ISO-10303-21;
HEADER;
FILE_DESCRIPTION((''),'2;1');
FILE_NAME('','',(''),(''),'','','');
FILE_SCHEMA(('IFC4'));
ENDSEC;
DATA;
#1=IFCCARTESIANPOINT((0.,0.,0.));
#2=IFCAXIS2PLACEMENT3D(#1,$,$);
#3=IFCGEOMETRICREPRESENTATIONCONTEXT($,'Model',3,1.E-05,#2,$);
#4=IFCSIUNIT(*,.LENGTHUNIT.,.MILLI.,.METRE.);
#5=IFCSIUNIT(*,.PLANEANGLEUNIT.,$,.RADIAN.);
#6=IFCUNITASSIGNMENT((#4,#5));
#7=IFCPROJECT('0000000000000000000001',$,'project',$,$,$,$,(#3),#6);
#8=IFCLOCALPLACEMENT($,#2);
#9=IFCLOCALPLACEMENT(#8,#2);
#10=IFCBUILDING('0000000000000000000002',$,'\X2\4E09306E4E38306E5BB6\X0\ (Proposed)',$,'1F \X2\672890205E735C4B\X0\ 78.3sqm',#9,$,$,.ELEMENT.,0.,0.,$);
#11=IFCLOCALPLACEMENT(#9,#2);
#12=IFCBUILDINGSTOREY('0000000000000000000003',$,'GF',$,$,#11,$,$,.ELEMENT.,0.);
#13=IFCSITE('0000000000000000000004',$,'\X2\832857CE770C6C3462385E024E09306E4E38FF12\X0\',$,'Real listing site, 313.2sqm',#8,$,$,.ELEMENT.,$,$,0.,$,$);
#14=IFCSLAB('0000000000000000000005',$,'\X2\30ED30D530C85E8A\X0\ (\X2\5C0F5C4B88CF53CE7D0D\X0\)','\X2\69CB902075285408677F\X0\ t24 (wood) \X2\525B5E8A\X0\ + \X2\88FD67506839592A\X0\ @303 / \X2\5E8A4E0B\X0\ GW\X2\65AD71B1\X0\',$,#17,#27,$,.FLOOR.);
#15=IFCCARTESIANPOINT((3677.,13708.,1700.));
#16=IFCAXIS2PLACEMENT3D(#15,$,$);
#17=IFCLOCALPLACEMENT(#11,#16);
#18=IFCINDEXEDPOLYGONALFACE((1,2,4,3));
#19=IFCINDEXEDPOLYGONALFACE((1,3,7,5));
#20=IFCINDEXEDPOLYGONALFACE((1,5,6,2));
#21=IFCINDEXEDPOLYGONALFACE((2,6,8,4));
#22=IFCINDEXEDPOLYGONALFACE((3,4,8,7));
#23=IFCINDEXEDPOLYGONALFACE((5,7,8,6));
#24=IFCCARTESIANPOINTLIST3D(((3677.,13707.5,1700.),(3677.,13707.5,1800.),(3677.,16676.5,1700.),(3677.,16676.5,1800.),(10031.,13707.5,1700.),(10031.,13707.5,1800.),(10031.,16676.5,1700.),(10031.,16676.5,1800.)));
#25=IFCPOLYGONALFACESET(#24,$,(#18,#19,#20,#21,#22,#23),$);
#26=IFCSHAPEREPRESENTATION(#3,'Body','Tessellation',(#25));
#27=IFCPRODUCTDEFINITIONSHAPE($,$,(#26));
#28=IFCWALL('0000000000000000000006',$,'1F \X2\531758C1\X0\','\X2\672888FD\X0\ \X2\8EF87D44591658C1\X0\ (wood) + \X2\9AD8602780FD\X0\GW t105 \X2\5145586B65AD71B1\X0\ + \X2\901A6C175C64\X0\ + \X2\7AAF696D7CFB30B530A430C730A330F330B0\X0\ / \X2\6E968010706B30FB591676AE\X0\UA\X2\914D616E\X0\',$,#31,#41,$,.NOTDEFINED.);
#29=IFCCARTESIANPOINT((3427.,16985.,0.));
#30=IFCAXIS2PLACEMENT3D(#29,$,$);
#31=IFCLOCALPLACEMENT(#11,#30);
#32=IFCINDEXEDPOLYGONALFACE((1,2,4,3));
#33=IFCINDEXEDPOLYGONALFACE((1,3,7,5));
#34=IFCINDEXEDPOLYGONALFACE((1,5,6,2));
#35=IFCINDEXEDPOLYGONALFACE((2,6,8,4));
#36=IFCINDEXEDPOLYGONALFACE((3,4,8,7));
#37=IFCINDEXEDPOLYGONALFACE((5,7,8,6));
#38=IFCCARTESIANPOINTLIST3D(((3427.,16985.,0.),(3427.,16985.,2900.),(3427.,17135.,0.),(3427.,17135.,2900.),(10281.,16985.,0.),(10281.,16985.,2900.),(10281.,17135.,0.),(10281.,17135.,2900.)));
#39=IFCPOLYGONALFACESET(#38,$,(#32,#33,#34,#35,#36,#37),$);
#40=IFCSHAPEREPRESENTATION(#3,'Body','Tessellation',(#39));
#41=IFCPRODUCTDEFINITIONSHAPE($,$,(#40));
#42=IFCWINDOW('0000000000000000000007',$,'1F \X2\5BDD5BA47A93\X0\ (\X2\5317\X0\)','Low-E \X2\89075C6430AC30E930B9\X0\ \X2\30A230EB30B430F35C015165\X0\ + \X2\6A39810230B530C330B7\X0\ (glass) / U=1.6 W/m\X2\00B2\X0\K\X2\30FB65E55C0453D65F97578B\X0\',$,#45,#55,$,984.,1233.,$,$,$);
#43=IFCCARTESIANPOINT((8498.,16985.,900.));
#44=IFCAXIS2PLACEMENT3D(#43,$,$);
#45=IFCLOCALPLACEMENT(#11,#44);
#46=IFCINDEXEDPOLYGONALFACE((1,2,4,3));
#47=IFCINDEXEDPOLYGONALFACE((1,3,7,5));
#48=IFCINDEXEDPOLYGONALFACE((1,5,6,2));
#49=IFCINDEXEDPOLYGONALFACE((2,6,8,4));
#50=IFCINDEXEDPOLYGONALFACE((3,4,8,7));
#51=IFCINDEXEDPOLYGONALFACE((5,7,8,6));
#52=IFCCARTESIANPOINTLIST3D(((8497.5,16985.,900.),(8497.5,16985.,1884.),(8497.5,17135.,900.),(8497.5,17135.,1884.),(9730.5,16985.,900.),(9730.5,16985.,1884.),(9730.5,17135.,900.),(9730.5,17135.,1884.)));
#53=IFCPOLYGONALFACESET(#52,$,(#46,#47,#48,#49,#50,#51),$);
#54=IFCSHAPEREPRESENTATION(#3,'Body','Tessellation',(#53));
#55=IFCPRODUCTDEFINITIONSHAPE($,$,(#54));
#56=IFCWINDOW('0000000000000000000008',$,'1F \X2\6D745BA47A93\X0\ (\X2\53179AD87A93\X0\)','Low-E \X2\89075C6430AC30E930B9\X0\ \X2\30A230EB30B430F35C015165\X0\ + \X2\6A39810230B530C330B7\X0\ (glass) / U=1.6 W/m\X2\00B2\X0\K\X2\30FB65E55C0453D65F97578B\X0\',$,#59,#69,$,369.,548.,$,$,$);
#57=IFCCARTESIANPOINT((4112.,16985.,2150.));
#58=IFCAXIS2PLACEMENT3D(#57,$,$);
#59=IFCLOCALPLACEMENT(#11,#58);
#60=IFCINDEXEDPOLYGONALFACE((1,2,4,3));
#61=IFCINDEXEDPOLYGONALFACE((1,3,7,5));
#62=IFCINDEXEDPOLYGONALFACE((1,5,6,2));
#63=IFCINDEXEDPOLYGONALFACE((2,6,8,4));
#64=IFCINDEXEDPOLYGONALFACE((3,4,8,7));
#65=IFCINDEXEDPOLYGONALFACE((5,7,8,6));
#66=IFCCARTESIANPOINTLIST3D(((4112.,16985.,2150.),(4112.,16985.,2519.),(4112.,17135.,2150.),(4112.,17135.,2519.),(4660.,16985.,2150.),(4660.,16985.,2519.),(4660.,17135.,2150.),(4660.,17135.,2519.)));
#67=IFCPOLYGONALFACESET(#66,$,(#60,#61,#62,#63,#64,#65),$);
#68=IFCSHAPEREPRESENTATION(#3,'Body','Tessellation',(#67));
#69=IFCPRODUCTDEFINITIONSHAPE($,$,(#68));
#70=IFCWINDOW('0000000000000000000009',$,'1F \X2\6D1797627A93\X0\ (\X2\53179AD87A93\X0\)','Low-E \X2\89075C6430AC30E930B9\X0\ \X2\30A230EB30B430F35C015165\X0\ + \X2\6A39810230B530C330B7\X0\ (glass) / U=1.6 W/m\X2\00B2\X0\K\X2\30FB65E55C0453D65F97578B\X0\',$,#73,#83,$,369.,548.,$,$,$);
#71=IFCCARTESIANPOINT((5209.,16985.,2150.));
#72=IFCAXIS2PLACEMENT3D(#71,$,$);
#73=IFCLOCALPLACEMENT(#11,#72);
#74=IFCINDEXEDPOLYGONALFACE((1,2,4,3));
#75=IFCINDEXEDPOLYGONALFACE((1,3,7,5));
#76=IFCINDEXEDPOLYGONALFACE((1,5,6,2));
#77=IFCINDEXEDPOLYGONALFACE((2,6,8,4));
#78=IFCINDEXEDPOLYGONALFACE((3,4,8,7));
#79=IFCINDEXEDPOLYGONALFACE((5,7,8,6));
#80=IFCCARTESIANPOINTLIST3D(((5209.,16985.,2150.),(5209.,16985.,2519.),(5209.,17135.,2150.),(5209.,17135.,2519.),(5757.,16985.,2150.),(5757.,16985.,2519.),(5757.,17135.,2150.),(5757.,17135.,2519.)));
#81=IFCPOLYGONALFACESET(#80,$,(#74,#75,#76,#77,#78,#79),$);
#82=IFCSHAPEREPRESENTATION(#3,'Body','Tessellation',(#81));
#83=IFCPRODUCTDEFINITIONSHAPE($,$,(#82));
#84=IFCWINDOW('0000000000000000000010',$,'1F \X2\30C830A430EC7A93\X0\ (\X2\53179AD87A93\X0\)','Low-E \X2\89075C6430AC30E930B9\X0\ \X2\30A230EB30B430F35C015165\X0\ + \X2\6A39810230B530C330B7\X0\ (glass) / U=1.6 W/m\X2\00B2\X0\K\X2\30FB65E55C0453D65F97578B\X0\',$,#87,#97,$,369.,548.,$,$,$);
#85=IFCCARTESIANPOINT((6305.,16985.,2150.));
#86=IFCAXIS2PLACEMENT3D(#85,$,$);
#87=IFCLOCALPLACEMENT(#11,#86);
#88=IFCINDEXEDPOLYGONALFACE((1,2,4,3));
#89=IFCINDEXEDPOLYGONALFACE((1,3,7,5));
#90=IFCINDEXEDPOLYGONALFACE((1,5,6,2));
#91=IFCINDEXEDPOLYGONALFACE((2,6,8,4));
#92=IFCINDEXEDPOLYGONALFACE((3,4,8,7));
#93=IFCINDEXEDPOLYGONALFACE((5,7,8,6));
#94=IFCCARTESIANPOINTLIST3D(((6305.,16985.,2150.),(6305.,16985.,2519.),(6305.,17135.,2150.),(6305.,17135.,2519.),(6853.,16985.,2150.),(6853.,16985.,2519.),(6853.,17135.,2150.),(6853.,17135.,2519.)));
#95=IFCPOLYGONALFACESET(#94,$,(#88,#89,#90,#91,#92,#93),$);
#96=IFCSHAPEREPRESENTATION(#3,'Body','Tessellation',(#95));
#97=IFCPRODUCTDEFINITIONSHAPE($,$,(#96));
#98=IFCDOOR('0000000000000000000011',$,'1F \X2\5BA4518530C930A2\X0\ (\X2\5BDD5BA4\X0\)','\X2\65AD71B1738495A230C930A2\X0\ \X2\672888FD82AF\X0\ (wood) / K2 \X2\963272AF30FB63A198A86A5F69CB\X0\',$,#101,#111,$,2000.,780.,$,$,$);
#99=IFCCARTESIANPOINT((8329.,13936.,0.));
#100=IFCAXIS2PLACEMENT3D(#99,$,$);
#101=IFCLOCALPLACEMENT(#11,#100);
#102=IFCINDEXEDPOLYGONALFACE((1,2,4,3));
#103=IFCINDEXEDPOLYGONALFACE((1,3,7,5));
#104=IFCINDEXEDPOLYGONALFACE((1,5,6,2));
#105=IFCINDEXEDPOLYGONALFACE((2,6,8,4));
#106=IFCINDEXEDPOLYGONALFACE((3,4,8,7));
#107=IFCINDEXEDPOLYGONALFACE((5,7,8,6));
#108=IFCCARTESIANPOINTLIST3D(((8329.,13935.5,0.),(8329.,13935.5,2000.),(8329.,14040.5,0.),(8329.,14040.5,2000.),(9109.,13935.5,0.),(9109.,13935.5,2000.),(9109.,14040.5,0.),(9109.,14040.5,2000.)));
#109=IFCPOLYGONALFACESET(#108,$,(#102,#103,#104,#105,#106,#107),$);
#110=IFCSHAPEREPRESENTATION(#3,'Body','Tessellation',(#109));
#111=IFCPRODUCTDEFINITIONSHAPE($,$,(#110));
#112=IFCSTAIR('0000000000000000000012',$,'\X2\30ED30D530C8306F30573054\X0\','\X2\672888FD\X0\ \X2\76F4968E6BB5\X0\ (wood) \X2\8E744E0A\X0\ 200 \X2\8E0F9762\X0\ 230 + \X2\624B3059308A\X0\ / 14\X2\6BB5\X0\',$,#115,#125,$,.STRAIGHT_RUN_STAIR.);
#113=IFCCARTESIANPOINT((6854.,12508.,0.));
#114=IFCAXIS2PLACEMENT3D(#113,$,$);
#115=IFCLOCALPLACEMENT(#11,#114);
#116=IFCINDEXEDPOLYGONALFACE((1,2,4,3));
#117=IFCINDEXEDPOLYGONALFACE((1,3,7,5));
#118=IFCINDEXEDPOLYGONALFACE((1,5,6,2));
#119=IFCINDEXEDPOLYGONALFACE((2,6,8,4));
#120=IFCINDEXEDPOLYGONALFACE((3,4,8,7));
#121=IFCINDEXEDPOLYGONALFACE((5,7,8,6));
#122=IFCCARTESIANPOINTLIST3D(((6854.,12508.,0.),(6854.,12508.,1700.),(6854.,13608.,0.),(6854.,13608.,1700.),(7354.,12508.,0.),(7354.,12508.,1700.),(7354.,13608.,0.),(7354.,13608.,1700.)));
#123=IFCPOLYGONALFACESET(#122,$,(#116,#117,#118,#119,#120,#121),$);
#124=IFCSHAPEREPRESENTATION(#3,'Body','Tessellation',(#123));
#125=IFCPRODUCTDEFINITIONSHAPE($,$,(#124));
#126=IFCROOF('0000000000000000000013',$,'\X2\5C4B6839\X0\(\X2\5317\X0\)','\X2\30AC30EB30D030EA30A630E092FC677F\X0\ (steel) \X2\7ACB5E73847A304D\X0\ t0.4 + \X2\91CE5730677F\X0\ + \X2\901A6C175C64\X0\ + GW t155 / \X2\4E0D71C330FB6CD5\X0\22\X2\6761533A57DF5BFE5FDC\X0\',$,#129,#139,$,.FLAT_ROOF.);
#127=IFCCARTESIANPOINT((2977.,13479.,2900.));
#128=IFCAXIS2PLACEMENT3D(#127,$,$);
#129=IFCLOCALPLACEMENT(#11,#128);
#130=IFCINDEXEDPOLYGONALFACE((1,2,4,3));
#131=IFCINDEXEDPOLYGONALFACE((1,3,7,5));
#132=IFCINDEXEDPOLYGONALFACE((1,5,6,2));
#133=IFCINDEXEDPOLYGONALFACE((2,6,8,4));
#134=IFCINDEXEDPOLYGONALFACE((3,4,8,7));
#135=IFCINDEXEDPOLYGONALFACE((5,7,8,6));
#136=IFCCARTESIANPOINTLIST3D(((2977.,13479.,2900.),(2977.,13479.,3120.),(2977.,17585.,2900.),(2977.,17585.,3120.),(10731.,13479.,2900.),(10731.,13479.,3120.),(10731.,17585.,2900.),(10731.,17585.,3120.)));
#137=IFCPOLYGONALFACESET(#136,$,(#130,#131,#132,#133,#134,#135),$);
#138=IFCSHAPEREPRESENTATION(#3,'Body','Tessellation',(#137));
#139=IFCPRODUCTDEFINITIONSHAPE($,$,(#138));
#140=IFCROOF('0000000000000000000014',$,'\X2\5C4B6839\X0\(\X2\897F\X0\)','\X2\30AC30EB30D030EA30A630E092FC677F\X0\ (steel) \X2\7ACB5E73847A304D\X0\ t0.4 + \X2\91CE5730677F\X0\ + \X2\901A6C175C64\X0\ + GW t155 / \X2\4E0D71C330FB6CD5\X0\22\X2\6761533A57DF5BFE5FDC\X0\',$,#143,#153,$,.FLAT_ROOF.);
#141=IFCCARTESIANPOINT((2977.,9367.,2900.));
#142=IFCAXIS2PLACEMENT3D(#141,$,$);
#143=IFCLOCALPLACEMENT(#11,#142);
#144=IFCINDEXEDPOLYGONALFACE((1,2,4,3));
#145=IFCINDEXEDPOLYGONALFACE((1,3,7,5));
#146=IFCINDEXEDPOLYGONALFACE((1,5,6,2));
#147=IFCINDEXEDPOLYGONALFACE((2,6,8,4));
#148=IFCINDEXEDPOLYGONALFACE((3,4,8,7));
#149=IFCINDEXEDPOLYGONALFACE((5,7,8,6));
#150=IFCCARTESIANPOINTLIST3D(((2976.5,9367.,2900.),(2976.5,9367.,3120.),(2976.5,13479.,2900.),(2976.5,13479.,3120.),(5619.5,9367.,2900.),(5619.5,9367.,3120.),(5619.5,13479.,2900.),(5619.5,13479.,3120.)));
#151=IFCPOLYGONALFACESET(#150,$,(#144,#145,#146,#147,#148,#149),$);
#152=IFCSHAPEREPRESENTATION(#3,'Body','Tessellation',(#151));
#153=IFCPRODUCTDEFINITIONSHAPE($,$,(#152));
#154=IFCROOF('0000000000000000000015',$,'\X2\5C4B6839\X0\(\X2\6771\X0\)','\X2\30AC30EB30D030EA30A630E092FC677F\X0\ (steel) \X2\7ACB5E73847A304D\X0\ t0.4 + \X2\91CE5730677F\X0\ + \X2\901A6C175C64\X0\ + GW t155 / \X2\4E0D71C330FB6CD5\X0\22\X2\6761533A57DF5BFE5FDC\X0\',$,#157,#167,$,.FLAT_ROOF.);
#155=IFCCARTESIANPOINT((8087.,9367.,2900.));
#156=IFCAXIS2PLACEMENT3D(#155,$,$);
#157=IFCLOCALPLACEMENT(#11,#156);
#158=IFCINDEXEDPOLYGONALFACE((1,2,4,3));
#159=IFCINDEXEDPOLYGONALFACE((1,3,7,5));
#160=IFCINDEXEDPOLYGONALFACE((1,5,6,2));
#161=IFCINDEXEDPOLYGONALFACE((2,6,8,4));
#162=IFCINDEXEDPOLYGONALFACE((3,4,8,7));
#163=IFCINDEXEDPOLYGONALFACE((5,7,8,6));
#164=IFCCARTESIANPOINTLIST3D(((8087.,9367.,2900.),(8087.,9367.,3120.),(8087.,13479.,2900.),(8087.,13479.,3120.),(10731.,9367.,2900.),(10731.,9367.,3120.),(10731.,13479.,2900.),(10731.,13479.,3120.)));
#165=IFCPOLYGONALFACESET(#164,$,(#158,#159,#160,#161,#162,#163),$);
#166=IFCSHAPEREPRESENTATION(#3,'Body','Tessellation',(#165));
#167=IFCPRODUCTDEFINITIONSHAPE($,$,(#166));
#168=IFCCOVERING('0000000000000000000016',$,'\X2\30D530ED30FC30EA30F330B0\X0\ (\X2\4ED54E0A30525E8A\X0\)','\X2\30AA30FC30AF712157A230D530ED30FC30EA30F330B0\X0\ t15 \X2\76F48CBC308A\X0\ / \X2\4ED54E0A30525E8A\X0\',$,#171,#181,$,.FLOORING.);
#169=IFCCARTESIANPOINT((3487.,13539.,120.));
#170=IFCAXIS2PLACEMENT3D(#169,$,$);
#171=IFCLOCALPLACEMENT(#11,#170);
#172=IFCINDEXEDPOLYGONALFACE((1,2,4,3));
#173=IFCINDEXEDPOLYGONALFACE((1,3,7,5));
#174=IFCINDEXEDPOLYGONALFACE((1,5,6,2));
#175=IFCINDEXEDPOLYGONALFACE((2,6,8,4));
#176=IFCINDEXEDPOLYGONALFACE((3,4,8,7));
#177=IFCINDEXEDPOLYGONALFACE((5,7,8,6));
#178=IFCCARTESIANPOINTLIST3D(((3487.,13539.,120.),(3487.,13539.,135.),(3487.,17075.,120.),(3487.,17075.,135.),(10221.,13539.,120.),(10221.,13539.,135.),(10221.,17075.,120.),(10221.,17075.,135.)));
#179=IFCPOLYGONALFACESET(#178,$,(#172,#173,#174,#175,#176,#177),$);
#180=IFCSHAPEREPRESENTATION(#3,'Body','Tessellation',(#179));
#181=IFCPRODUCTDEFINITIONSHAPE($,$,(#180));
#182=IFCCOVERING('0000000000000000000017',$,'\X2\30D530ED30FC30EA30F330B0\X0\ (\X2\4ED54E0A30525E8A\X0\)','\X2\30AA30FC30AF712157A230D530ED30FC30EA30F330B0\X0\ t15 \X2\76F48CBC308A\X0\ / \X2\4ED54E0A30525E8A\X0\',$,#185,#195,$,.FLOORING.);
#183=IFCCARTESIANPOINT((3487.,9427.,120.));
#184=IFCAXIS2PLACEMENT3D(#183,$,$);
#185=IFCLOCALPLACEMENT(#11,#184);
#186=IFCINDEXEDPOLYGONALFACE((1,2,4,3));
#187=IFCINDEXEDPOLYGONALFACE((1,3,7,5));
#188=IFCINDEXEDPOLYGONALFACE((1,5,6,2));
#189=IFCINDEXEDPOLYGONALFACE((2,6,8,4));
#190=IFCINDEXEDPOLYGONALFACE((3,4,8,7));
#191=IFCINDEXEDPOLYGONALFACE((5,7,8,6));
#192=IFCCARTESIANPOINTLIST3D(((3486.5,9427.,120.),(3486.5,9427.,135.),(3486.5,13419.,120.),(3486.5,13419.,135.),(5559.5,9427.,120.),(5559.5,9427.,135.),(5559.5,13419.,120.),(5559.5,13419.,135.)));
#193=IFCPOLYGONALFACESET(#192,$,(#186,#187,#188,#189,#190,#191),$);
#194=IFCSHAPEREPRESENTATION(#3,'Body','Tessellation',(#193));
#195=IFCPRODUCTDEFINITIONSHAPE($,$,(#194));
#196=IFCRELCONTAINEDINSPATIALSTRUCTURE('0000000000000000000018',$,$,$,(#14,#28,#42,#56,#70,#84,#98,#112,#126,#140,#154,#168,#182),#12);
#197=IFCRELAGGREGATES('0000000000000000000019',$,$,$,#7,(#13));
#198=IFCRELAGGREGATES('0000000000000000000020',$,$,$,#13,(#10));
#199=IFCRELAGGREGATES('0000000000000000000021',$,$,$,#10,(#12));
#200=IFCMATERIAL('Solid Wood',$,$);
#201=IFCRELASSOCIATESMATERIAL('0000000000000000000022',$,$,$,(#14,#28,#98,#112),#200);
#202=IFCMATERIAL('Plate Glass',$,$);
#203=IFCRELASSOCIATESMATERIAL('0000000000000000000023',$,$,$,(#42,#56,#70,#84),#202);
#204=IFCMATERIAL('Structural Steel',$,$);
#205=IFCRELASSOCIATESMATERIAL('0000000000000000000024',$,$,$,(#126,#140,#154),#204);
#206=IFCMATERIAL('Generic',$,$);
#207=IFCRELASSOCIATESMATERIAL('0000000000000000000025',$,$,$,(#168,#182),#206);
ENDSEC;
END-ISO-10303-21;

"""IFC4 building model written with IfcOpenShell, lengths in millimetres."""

from ifc_helpers import new_model, si_unit, frame, frame_2d, origin, place, context, project, spatial, rectangle, extrude, material, element, fill, save


model = new_model("IFC4")

# Units and contexts
model_context = context("Model", 3, precision=1e-05, world=origin())
ifc_project = project(units=[si_unit("LENGTHUNIT", "METRE", prefix="MILLI"), si_unit("PLANEANGLEUNIT", "RADIAN")], contexts=[model_context])

# Site, building, storey
site_placement = place(None, origin())
site = spatial("IfcSite", under=ifc_project, at=site_placement, Name="茨城県水戸市三の丸２", ObjectType="Real listing site, 313.2sqm", CompositionType="ELEMENT", RefElevation=0.0)
building_placement = place(site_placement, origin())
building = spatial("IfcBuilding", under=site, at=building_placement, Name="三の丸の家 (Proposed)", ObjectType="1F 木造平屋 78.3sqm", CompositionType="ELEMENT", ElevationOfRefHeight=0.0, ElevationOfTerrain=0.0)
storey_placement = place(building_placement, origin())
storey = spatial("IfcBuildingStorey", under=building, at=storey_placement, Name="GF", CompositionType="ELEMENT", Elevation=0.0)

# Slab
ifc_material_1 = material(Name="Solid Wood")
slab_1_placement = place(storey_placement, frame((3677.0, 13708.0, 1700.0)))
element("IfcSlab", 1, at=slab_1_placement, inside=storey, material=ifc_material_1, Name="ロフト床 (小屋裏収納)", Description="構造用合板 t24 (wood) 剛床 + 製材根太 @303 / 床下 GW断熱", PredefinedType="FLOOR", context=model_context, shape_type="SweptSolid", body=[
    extrude(rectangle(XDim=6354.0, YDim=2969.0, at=frame_2d((3177.0, 1484.0))), frame((3677.0, 13708.0, 1700.0)), (0.0, 0.0, 1.0), 100.0),
])

# Wall, openings, windows
wall_1_placement = place(storey_placement, frame((3427.0, 16985.0, 0.0)))
wall_1 = element("IfcWall", 2, at=wall_1_placement, inside=storey, material=ifc_material_1, Name="1F 北壁", Description="木製 軸組外壁 (wood) + 高性能GW t105 充填断熱 + 通気層 + 窯業系サイディング / 準耐火・外皮UA配慮", PredefinedType="NOTDEFINED", context=model_context, shape_type="SweptSolid", body=[
    extrude(rectangle(XDim=6854.0, YDim=150.0, at=frame_2d((3427.0, 75.0))), frame((3427.0, 16985.0, 0.0)), (0.0, 0.0, 1.0), 2900.0),
])
opening_1_placement = place(storey_placement, frame((8498.0, 16985.0, 900.0)))
opening_1 = element("IfcOpeningElement", 3, at=opening_1_placement, cuts=wall_1, PredefinedType="NOTDEFINED", context=model_context, shape_type="SweptSolid", body=[
    extrude(rectangle(XDim=1233.0, YDim=150.0, at=frame_2d((616.0, 75.0))), frame((8498.0, 16985.0, 900.0)), (0.0, 0.0, 1.0), 984.0),
])
opening_2_placement = place(storey_placement, frame((4112.0, 16985.0, 2150.0)))
opening_2 = element("IfcOpeningElement", 4, at=opening_2_placement, cuts=wall_1, PredefinedType="NOTDEFINED", context=model_context, shape_type="SweptSolid", body=[
    extrude(rectangle(XDim=548.0, YDim=150.0, at=frame_2d((274.0, 75.0))), frame((4112.0, 16985.0, 2150.0)), (0.0, 0.0, 1.0), 369.0),
])
opening_3_placement = place(storey_placement, frame((5209.0, 16985.0, 2150.0)))
opening_3 = element("IfcOpeningElement", 5, at=opening_3_placement, cuts=wall_1, PredefinedType="NOTDEFINED", context=model_context, shape_type="SweptSolid", body=[
    extrude(rectangle(XDim=548.0, YDim=150.0, at=frame_2d((274.0, 75.0))), frame((5209.0, 16985.0, 2150.0)), (0.0, 0.0, 1.0), 369.0),
])
opening_4_placement = place(storey_placement, frame((6305.0, 16985.0, 2150.0)))
opening_4 = element("IfcOpeningElement", 6, at=opening_4_placement, cuts=wall_1, PredefinedType="NOTDEFINED", context=model_context, shape_type="SweptSolid", body=[
    extrude(rectangle(XDim=548.0, YDim=150.0, at=frame_2d((274.0, 75.0))), frame((6305.0, 16985.0, 2150.0)), (0.0, 0.0, 1.0), 369.0),
])
ifc_material_2 = material(Name="Plate Glass")
window_1_placement = place(storey_placement, frame((8498.0, 16985.0, 900.0)))
window_1 = element("IfcWindow", 7, at=window_1_placement, inside=storey, material=ifc_material_2, Name="1F 寝室窓 (北)", Description="Low-E 複層ガラス アルゴン封入 + 樹脂サッシ (glass) / U=1.6 W/m²K・日射取得型", OverallHeight=984.0, OverallWidth=1233.0, context=model_context, shape_type="SweptSolid", body=[
    extrude(rectangle(XDim=1233.0, YDim=150.0, at=frame_2d((616.0, 75.0))), frame((8498.0, 16985.0, 900.0)), (0.0, 0.0, 1.0), 984.0),
])
fill(opening_1, window_1)
window_2_placement = place(storey_placement, frame((4112.0, 16985.0, 2150.0)))
window_2 = element("IfcWindow", 8, at=window_2_placement, inside=storey, material=ifc_material_2, Name="1F 浴室窓 (北高窓)", Description="Low-E 複層ガラス アルゴン封入 + 樹脂サッシ (glass) / U=1.6 W/m²K・日射取得型", OverallHeight=369.0, OverallWidth=548.0, context=model_context, shape_type="SweptSolid", body=[
    extrude(rectangle(XDim=548.0, YDim=150.0, at=frame_2d((274.0, 75.0))), frame((4112.0, 16985.0, 2150.0)), (0.0, 0.0, 1.0), 369.0),
])
fill(opening_2, window_2)
window_3_placement = place(storey_placement, frame((5209.0, 16985.0, 2150.0)))
window_3 = element("IfcWindow", 9, at=window_3_placement, inside=storey, material=ifc_material_2, Name="1F 洗面窓 (北高窓)", Description="Low-E 複層ガラス アルゴン封入 + 樹脂サッシ (glass) / U=1.6 W/m²K・日射取得型", OverallHeight=369.0, OverallWidth=548.0, context=model_context, shape_type="SweptSolid", body=[
    extrude(rectangle(XDim=548.0, YDim=150.0, at=frame_2d((274.0, 75.0))), frame((5209.0, 16985.0, 2150.0)), (0.0, 0.0, 1.0), 369.0),
])
fill(opening_3, window_3)
window_4_placement = place(storey_placement, frame((6305.0, 16985.0, 2150.0)))
window_4 = element("IfcWindow", 10, at=window_4_placement, inside=storey, material=ifc_material_2, Name="1F トイレ窓 (北高窓)", Description="Low-E 複層ガラス アルゴン封入 + 樹脂サッシ (glass) / U=1.6 W/m²K・日射取得型", OverallHeight=369.0, OverallWidth=548.0, context=model_context, shape_type="SweptSolid", body=[
    extrude(rectangle(XDim=548.0, YDim=150.0, at=frame_2d((274.0, 75.0))), frame((6305.0, 16985.0, 2150.0)), (0.0, 0.0, 1.0), 369.0),
])
fill(opening_4, window_4)

# Door
door_1_placement = place(storey_placement, frame((8329.0, 13936.0, 0.0)))
element("IfcDoor", 11, at=door_1_placement, inside=storey, material=ifc_material_1, Name="1F 室内ドア (寝室)", Description="断熱玄関ドア 木製芯 (wood) / K2 防犯・採風機構", OverallHeight=2000.0, OverallWidth=780.0, context=model_context, shape_type="SweptSolid", body=[
    extrude(rectangle(XDim=780.0, YDim=105.0, at=frame_2d((390.0, 52.0))), frame((8329.0, 13936.0, 0.0)), (0.0, 0.0, 1.0), 2000.0),
])

# Stair
stair_placement = place(storey_placement, frame((6854.0, 12508.0, 0.0)))
element("IfcStair", 12, at=stair_placement, inside=storey, material=ifc_material_1, Name="ロフトはしご", Description="木製 直階段 (wood) 蹴上 200 踏面 230 + 手すり / 14段", PredefinedType="STRAIGHT_RUN_STAIR", context=model_context, shape_type="SweptSolid", body=[
    extrude(rectangle(XDim=500.0, YDim=1100.0, at=frame_2d((250.0, 550.0))), frame((6854.0, 12508.0, 0.0)), (0.0, 0.0, 1.0), 1700.0),
])

# Roofs
ifc_material_3 = material(Name="Structural Steel")
roof_1_placement = place(storey_placement, frame((2977.0, 13479.0, 2900.0)))
element("IfcRoof", 13, at=roof_1_placement, inside=storey, material=ifc_material_3, Name="屋根(北)", Description="ガルバリウム鋼板 (steel) 立平葺き t0.4 + 野地板 + 通気層 + GW t155 / 不燃・法22条区域対応", PredefinedType="FLAT_ROOF", context=model_context, shape_type="SweptSolid", body=[
    extrude(rectangle(XDim=7754.0, YDim=4106.0, at=frame_2d((3877.0, 2053.0))), frame((2977.0, 13479.0, 2900.0)), (0.0, 0.0, 1.0), 220.0),
])
roof_2_placement = place(storey_placement, frame((2977.0, 9367.0, 2900.0)))
element("IfcRoof", 14, at=roof_2_placement, inside=storey, material=ifc_material_3, Name="屋根(西)", Description="ガルバリウム鋼板 (steel) 立平葺き t0.4 + 野地板 + 通気層 + GW t155 / 不燃・法22条区域対応", PredefinedType="FLAT_ROOF", context=model_context, shape_type="SweptSolid", body=[
    extrude(rectangle(XDim=2643.0, YDim=4112.0, at=frame_2d((1321.0, 2056.0))), frame((2977.0, 9367.0, 2900.0)), (0.0, 0.0, 1.0), 220.0),
])
roof_3_placement = place(storey_placement, frame((8087.0, 9367.0, 2900.0)))
element("IfcRoof", 15, at=roof_3_placement, inside=storey, material=ifc_material_3, Name="屋根(東)", Description="ガルバリウム鋼板 (steel) 立平葺き t0.4 + 野地板 + 通気層 + GW t155 / 不燃・法22条区域対応", PredefinedType="FLAT_ROOF", context=model_context, shape_type="SweptSolid", body=[
    extrude(rectangle(XDim=2644.0, YDim=4112.0, at=frame_2d((1322.0, 2056.0))), frame((8087.0, 9367.0, 2900.0)), (0.0, 0.0, 1.0), 220.0),
])

# Coverings
ifc_material_4 = material(Name="Generic")
covering_1_placement = place(storey_placement, frame((3487.0, 13539.0, 120.0)))
element("IfcCovering", 16, at=covering_1_placement, inside=storey, material=ifc_material_4, Name="フローリング (仕上げ床)", Description="オーク無垢フローリング t15 直貼り / 仕上げ床", PredefinedType="FLOORING", context=model_context, shape_type="SweptSolid", body=[
    extrude(rectangle(XDim=6734.0, YDim=3536.0, at=frame_2d((3367.0, 1768.0))), frame((3487.0, 13539.0, 120.0)), (0.0, 0.0, 1.0), 15.0),
])
covering_2_placement = place(storey_placement, frame((3487.0, 9427.0, 120.0)))
element("IfcCovering", 17, at=covering_2_placement, inside=storey, material=ifc_material_4, Name="フローリング (仕上げ床)", Description="オーク無垢フローリング t15 直貼り / 仕上げ床", PredefinedType="FLOORING", context=model_context, shape_type="SweptSolid", body=[
    extrude(rectangle(XDim=2073.0, YDim=3992.0, at=frame_2d((1036.0, 1996.0))), frame((3487.0, 9427.0, 120.0)), (0.0, 0.0, 1.0), 15.0),
])

save(model, "model.ifc")
